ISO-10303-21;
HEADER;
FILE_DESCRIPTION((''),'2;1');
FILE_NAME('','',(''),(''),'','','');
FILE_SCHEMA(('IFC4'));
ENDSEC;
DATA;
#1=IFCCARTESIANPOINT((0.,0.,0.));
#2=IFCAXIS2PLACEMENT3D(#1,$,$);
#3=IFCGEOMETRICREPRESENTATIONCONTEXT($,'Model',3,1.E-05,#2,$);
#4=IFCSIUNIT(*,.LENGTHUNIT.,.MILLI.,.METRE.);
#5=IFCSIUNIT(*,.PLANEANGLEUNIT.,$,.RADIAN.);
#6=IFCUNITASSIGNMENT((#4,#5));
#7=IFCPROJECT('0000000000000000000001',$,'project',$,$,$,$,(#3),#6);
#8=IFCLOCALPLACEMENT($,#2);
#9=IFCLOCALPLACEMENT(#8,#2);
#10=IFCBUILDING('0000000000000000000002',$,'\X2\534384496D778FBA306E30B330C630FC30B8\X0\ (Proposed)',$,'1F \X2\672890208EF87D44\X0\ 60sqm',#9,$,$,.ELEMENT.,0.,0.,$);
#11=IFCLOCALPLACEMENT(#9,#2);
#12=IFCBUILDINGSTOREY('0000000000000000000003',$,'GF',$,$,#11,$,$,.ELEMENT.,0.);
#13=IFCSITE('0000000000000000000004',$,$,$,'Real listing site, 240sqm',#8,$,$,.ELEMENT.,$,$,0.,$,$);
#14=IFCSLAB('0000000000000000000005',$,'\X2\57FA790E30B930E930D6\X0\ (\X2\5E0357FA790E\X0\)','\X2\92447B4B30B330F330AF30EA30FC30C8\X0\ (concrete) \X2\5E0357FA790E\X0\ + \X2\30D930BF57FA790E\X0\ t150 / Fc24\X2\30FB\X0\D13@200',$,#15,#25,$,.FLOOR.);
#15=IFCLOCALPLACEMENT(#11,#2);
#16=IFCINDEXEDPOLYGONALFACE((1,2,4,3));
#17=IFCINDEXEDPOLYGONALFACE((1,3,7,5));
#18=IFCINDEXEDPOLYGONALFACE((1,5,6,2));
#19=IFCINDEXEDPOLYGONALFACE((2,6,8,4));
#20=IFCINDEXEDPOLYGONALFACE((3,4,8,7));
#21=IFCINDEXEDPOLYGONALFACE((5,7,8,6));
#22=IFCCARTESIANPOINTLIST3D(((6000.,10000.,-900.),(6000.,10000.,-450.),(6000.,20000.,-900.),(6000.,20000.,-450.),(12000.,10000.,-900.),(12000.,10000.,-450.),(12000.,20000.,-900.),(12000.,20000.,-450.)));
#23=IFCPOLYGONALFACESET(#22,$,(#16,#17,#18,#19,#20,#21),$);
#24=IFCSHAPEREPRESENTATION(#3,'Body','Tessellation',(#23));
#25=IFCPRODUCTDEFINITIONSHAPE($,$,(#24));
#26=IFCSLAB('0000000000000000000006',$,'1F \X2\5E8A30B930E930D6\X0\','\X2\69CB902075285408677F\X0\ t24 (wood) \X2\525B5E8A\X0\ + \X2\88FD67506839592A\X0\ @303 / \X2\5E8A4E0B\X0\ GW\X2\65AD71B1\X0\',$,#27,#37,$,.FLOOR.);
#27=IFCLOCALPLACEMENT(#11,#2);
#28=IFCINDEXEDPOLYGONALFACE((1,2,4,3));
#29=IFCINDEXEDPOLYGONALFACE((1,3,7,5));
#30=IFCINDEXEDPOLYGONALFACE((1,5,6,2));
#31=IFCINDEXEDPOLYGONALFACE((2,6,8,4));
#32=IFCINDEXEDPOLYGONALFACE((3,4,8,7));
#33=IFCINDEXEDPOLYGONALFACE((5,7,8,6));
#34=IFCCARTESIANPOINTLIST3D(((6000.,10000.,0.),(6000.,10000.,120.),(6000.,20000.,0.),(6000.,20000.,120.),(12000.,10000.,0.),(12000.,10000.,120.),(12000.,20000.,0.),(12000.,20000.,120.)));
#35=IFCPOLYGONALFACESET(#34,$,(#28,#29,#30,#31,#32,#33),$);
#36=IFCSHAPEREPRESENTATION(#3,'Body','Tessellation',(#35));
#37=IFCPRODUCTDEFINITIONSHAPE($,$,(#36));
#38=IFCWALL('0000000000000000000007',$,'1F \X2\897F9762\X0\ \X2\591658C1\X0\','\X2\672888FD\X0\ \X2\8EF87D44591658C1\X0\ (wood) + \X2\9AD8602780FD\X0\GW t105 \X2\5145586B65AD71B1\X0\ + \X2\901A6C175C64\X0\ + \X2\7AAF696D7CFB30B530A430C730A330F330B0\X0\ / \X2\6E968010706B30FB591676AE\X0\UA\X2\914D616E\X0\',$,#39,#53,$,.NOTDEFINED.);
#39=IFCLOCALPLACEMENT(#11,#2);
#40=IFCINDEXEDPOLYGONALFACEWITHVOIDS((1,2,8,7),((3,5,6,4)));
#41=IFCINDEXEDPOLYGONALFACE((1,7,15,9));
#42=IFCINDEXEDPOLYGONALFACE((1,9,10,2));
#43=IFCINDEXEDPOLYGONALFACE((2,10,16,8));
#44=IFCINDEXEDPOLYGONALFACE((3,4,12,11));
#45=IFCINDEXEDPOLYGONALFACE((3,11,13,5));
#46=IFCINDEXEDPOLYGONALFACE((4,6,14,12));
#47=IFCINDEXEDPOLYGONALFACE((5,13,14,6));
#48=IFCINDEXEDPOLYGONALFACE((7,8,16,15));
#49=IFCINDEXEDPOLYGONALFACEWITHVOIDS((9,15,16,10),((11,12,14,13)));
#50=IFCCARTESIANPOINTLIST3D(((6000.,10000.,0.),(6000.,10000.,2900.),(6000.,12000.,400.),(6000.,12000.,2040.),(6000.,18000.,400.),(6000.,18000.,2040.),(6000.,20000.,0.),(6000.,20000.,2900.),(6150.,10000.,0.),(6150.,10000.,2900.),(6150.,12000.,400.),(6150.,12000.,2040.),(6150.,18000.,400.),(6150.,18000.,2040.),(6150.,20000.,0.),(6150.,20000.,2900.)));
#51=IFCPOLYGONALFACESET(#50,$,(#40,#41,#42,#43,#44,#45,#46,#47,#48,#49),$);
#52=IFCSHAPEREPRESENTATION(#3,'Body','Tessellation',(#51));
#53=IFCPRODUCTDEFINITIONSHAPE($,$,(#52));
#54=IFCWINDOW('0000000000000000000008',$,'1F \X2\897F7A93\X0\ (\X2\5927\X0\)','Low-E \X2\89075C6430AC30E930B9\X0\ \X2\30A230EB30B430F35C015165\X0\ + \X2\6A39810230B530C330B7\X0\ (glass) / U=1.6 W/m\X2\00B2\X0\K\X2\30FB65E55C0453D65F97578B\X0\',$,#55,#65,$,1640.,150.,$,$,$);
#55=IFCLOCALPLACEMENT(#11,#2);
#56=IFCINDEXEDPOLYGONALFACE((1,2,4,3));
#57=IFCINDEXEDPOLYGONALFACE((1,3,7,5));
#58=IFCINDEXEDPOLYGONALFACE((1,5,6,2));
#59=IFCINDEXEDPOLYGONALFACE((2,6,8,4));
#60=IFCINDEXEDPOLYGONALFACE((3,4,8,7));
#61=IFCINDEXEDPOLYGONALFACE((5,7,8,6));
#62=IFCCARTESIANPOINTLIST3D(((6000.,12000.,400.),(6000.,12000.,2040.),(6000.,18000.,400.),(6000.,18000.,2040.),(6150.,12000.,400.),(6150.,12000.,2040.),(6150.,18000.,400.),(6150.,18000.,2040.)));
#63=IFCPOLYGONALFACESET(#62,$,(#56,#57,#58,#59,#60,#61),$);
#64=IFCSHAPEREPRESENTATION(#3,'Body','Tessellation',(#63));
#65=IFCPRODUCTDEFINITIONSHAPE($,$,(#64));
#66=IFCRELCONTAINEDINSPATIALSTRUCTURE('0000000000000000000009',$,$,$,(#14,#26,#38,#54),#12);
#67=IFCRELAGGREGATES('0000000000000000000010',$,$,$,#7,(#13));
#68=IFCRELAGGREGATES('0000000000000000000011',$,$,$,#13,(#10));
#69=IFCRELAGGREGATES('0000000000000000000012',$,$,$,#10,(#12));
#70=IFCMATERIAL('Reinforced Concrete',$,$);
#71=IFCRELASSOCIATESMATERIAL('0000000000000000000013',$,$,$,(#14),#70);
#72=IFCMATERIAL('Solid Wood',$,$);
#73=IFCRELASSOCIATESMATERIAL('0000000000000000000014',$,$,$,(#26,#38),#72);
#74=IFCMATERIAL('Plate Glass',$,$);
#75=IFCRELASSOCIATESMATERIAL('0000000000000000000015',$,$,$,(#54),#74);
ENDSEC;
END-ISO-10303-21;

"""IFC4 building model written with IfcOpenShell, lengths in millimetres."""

from ifc_helpers import new_model, si_unit, frame, frame_2d, origin, place, context, project, spatial, rectangle, extrude, material, element, fill, save


model = new_model("IFC4")

# Units and contexts
model_context = context("Model", 3, precision=1e-05, world=origin())
ifc_project = project(units=[si_unit("LENGTHUNIT", "METRE", prefix="MILLI"), si_unit("PLANEANGLEUNIT", "RADIAN")], contexts=[model_context])

# Site, building, storey
site_placement = place(None, origin())
site = spatial("IfcSite", under=ifc_project, at=site_placement, ObjectType="Real listing site, 240sqm", CompositionType="ELEMENT", RefElevation=0.0)
building_placement = place(site_placement, origin())
building = spatial("IfcBuilding", under=site, at=building_placement, Name="千葉海辺のコテージ (Proposed)", ObjectType="1F 木造軸組 60sqm", CompositionType="ELEMENT", ElevationOfRefHeight=0.0, ElevationOfTerrain=0.0)
storey_placement = place(building_placement, origin())
storey = spatial("IfcBuildingStorey", under=building, at=storey_placement, Name="GF", CompositionType="ELEMENT", Elevation=0.0)

# Slabs
ifc_material_1 = material(Name="Reinforced Concrete")
slab_1_placement = place(storey_placement, frame((3000.0, 5000.0, -450.0)))
element("IfcSlab", 1, at=slab_1_placement, inside=storey, material=ifc_material_1, Name="基礎スラブ (布基礎)", Description="鉄筋コンクリート (concrete) 布基礎 + ベタ基礎 t150 / Fc24・D13@200", PredefinedType="FLOOR", context=model_context, shape_type="SweptSolid", body=[
    extrude(rectangle(XDim=6000.0, YDim=10000.0, at=frame_2d((3000.0, 5000.0))), frame((3000.0, 5000.0, -450.0)), (0.0, 0.0, 1.0), 450.0),
])
ifc_material_2 = material(Name="Solid Wood")
slab_2_placement = place(storey_placement, frame((3000.0, 5000.0, 0.0)))
element("IfcSlab", 2, at=slab_2_placement, inside=storey, material=ifc_material_2, Name="1F 床スラブ", Description="構造用合板 t24 (wood) 剛床 + 製材根太 @303 / 床下 GW断熱", PredefinedType="FLOOR", context=model_context, shape_type="SweptSolid", body=[
    extrude(rectangle(XDim=6000.0, YDim=10000.0, at=frame_2d((3000.0, 5000.0))), frame((3000.0, 5000.0, 0.0)), (0.0, 0.0, 1.0), 120.0),
])

# Shared definitions
ifc_material_3 = material(Name="Plate Glass")

# Wall, opening, window
wall_1_placement = place(storey_placement, frame((3000.0, 5000.0, 0.0)))
wall_1 = element("IfcWall", 3, at=wall_1_placement, inside=storey, material=ifc_material_2, Name="1F 西面 外壁", Description="木製 軸組外壁 (wood) + 高性能GW t105 充填断熱 + 通気層 + 窯業系サイディング / 準耐火・外皮UA配慮", PredefinedType="NOTDEFINED", context=model_context, shape_type="SweptSolid", body=[
    extrude(rectangle(XDim=150.0, YDim=10000.0, at=frame_2d((75.0, 5000.0))), frame((3000.0, 5000.0, 0.0)), (0.0, 0.0, 1.0), 2900.0),
])
opening_1_placement = place(storey_placement, frame((3000.0, 6000.0, 200.0)))
opening_1 = element("IfcOpeningElement", 4, at=opening_1_placement, cuts=wall_1, PredefinedType="NOTDEFINED", context=model_context, shape_type="SweptSolid", body=[
    extrude(rectangle(XDim=150.0, YDim=6000.0, at=frame_2d((75.0, 3000.0))), frame((3000.0, 6000.0, 200.0)), (0.0, 0.0, 1.0), 1640.0),
])
window_1_placement = place(storey_placement, frame((3000.0, 6000.0, 200.0)))
window_1 = element("IfcWindow", 5, at=window_1_placement, inside=storey, material=ifc_material_3, Name="1F 西窓 (大)", Description="Low-E 複層ガラス アルゴン封入 + 樹脂サッシ (glass) / U=1.6 W/m²K・日射取得型", OverallHeight=1640.0, OverallWidth=150.0, context=model_context, shape_type="SweptSolid", body=[
    extrude(rectangle(XDim=150.0, YDim=6000.0, at=frame_2d((75.0, 3000.0))), frame((3000.0, 6000.0, 200.0)), (0.0, 0.0, 1.0), 1640.0),
])
fill(opening_1, window_1)

save(model, "model.ifc")
